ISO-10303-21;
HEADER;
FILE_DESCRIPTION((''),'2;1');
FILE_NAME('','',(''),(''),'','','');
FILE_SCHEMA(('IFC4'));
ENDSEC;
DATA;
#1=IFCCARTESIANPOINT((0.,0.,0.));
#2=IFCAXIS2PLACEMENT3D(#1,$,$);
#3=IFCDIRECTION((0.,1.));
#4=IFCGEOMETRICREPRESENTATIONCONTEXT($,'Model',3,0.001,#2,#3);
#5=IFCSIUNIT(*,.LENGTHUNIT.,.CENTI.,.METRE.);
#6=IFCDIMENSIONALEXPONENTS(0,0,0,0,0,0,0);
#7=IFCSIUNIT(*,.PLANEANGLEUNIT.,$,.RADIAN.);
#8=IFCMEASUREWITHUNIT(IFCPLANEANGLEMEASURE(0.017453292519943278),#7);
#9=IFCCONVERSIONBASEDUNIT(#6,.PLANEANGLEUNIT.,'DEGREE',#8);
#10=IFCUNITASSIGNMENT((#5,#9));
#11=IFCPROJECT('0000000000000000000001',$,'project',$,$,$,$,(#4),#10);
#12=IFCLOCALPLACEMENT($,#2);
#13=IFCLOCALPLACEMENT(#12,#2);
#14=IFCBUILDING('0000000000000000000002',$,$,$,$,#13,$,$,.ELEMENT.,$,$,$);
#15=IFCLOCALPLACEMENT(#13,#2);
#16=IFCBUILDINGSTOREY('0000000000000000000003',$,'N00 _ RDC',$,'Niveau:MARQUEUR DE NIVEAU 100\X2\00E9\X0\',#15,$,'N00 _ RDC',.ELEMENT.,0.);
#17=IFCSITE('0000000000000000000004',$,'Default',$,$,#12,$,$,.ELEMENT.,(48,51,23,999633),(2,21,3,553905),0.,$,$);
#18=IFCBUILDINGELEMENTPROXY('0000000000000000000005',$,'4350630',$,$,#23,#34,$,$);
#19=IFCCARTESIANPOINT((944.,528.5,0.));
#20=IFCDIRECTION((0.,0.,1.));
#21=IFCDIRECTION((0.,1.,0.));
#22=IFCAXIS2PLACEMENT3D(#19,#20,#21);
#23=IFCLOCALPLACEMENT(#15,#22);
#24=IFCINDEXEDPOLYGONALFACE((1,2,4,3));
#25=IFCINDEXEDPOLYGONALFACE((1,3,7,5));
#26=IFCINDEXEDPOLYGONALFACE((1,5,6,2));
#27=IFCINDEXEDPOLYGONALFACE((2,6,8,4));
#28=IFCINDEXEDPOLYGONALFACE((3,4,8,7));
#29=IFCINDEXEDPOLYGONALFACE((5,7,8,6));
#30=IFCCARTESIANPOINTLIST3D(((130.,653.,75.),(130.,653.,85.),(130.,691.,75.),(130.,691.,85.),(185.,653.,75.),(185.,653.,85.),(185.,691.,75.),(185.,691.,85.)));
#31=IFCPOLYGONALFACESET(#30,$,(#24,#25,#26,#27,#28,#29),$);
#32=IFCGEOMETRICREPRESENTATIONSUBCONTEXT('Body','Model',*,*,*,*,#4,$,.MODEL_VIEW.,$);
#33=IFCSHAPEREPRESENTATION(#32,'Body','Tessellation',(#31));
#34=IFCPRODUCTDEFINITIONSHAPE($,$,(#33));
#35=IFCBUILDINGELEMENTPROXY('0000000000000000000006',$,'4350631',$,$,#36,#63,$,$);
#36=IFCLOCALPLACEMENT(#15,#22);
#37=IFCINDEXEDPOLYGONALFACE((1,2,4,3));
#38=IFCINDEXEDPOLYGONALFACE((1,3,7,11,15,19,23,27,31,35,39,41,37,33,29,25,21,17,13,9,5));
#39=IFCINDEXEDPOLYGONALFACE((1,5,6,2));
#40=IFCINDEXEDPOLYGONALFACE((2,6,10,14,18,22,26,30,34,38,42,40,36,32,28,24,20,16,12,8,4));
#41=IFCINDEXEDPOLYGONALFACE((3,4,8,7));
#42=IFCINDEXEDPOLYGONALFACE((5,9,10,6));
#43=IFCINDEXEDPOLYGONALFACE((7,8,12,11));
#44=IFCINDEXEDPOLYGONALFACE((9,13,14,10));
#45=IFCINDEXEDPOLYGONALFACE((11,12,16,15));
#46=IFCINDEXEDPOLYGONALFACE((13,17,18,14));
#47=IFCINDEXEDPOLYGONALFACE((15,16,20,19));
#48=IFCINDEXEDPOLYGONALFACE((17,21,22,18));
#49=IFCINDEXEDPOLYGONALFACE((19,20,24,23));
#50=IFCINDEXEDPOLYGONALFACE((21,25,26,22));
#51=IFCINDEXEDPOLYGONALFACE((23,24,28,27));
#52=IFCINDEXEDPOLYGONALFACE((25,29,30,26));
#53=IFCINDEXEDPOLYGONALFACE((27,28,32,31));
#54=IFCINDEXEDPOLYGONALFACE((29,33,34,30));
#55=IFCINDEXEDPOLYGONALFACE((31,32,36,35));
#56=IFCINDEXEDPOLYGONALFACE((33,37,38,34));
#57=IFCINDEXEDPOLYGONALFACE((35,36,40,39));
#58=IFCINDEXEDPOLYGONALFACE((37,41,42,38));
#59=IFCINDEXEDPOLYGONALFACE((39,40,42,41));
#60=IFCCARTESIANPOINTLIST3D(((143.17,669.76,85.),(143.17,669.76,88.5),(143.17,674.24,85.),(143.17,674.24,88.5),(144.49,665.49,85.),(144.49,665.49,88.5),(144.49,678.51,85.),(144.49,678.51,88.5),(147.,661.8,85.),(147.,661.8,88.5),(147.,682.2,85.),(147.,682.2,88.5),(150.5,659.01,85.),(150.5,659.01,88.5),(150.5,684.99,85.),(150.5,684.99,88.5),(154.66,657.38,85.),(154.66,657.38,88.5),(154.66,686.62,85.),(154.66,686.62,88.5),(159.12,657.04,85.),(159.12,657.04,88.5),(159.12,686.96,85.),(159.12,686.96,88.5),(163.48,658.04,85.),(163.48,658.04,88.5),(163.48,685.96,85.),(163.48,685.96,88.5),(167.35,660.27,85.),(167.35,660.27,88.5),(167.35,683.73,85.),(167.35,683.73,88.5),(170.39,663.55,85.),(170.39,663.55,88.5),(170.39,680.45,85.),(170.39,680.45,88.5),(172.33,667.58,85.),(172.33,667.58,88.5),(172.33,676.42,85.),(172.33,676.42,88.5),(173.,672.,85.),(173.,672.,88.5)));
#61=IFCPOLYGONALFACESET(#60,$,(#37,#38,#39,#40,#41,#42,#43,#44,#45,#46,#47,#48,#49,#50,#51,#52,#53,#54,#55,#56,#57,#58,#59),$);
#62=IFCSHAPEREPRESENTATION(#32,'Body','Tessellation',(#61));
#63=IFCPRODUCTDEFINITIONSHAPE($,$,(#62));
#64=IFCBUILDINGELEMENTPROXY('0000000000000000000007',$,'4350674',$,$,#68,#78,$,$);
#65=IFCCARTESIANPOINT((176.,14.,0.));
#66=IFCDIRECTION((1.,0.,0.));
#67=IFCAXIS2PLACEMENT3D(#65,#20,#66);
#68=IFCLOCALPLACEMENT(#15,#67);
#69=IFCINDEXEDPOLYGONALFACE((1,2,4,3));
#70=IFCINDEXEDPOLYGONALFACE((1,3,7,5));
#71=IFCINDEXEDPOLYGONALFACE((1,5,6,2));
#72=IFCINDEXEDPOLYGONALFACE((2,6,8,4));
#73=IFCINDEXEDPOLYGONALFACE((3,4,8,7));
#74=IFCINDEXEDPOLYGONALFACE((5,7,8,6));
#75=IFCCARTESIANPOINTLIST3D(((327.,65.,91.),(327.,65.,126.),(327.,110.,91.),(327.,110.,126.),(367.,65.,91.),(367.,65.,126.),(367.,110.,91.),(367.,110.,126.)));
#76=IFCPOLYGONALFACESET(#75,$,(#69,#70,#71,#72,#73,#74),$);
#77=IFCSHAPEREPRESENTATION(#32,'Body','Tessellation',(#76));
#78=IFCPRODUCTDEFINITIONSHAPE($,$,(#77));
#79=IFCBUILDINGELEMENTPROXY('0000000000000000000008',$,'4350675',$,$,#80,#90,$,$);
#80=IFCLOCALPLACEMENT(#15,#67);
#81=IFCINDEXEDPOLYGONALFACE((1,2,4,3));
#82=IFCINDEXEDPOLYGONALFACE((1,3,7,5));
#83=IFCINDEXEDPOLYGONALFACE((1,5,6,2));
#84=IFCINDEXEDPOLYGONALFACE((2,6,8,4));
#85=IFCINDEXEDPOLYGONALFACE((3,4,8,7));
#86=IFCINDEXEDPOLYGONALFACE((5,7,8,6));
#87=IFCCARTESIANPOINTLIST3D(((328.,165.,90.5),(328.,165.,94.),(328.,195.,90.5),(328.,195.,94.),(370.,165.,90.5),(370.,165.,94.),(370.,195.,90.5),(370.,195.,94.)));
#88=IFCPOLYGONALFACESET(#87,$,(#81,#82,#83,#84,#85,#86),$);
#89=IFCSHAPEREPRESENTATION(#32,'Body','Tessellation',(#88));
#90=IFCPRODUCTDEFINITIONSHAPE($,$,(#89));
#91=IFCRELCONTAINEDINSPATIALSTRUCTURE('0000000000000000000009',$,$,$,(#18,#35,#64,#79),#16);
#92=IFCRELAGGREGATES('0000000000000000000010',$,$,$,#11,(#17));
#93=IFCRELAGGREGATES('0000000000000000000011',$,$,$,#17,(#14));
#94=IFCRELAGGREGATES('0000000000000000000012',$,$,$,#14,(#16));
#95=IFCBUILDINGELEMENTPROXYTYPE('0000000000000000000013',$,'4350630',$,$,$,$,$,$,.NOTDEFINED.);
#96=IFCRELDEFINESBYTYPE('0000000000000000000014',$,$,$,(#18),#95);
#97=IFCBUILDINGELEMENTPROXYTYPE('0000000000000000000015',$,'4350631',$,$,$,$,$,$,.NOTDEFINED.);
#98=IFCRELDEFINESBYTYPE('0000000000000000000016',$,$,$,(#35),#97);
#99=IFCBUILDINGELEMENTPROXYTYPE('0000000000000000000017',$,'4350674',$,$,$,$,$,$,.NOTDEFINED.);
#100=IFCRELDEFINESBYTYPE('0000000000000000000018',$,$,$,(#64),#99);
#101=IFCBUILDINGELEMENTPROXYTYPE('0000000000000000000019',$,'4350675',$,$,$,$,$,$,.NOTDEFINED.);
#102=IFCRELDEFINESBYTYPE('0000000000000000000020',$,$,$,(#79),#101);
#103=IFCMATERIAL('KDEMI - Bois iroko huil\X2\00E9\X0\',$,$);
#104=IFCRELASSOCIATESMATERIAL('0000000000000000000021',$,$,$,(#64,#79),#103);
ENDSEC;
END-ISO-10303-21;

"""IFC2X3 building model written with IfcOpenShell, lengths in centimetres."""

from ifc_helpers import new_model, entity, si_unit, converted_unit, direction, frame, origin, origin_2d_with_axis, place, context, subcontext, project, spatial, rectangle, circle, extrude, material, type_object, element, save


model = new_model("IFC2X3")

# Units and contexts
model_context = context("Model", 3, precision=0.001, world=origin(), true_north=direction((0.0, 1.0)))
body_context = subcontext(model_context, "Body", "Model", "MODEL_VIEW")
ifc_project = project(units=[si_unit("LENGTHUNIT", "METRE", prefix="CENTI"), converted_unit("PLANEANGLEUNIT", "DEGREE", entity("IfcPlaneAngleMeasure", 0.017453292519943278), si_unit("PLANEANGLEUNIT", "RADIAN"), dimensions=[0, 0, 0, 0, 0, 0, 0])], contexts=[model_context])

# Site, building, storey
site_placement = place(None, origin())
site = spatial("IfcSite", under=ifc_project, at=site_placement, Name="Default", CompositionType="ELEMENT", RefLatitude=(48, 51, 23, 999633), RefLongitude=(2, 21, 3, 553905), RefElevation=0.0)
building_placement = place(site_placement, origin())
building = spatial("IfcBuilding", under=site, at=building_placement, CompositionType="ELEMENT")
storey_placement = place(building_placement, origin())
storey = spatial("IfcBuildingStorey", under=building, at=storey_placement, Name="N00 _ RDC", ObjectType="Niveau:MARQUEUR DE NIVEAU 100é", LongName="N00 _ RDC", CompositionType="ELEMENT", Elevation=0.0)

# Shared definitions
ifc_material_1 = material(Name="KDEMI - Bois iroko huilé")

# Building element proxies
building_element_proxy_type_1 = type_object("IfcBuildingElementProxyType", Name="4350630", PredefinedType="NOTDEFINED")
proxy_1_placement = place(storey_placement, frame((944.0, 528.5, 0.0), z_axis=(0.0, 0.0, 1.0), x_axis=(0.0, 1.0, 0.0)))
element("IfcBuildingElementProxy", 1, at=proxy_1_placement, inside=storey, type_object=building_element_proxy_type_1, Name="4350630", context=body_context, shape_type="SweptSolid", body=[
    extrude(rectangle(XDim=55.0, YDim=38.0, at=origin_2d_with_axis()), frame((157.5, 672.0, 75.0)), (0.0, 0.0, 1.0), 10.0),
])
building_element_proxy_type_2 = type_object("IfcBuildingElementProxyType", Name="4350631", PredefinedType="NOTDEFINED")
proxy_2_placement = place(storey_placement, frame((944.0, 528.5, 0.0), z_axis=(0.0, 0.0, 1.0), x_axis=(0.0, 1.0, 0.0)))
element("IfcBuildingElementProxy", 2, at=proxy_2_placement, inside=storey, type_object=building_element_proxy_type_2, Name="4350631", context=body_context, shape_type="SweptSolid", body=[
    extrude(circle(Radius=15.0, at=origin_2d_with_axis()), frame((158.0, 672.0, 85.0)), (0.0, 0.0, 1.0), 3.5),
])
building_element_proxy_type_3 = type_object("IfcBuildingElementProxyType", Name="4350674", PredefinedType="NOTDEFINED")
proxy_3_placement = place(storey_placement, frame((176.0, 14.0, 0.0), z_axis=(0.0, 0.0, 1.0), x_axis=(1.0, 0.0, 0.0)))
element("IfcBuildingElementProxy", 3, at=proxy_3_placement, inside=storey, type_object=building_element_proxy_type_3, material=ifc_material_1, Name="4350674", context=body_context, shape_type="SweptSolid", body=[
    extrude(rectangle(XDim=40.0, YDim=45.0, at=origin_2d_with_axis()), frame((347.0, 87.5, 91.0)), (0.0, 0.0, 1.0), 35.0),
])
building_element_proxy_type_4 = type_object("IfcBuildingElementProxyType", Name="4350675", PredefinedType="NOTDEFINED")
proxy_4_placement = place(storey_placement, frame((176.0, 14.0, 0.0), z_axis=(0.0, 0.0, 1.0), x_axis=(1.0, 0.0, 0.0)))
element("IfcBuildingElementProxy", 4, at=proxy_4_placement, inside=storey, type_object=building_element_proxy_type_4, material=ifc_material_1, Name="4350675", context=body_context, shape_type="SweptSolid", body=[
    extrude(rectangle(XDim=42.0, YDim=30.0, at=origin_2d_with_axis()), frame((349.0, 180.0, 90.5)), (0.0, 0.0, 1.0), 3.5),
])

save(model, "model.ifc")
